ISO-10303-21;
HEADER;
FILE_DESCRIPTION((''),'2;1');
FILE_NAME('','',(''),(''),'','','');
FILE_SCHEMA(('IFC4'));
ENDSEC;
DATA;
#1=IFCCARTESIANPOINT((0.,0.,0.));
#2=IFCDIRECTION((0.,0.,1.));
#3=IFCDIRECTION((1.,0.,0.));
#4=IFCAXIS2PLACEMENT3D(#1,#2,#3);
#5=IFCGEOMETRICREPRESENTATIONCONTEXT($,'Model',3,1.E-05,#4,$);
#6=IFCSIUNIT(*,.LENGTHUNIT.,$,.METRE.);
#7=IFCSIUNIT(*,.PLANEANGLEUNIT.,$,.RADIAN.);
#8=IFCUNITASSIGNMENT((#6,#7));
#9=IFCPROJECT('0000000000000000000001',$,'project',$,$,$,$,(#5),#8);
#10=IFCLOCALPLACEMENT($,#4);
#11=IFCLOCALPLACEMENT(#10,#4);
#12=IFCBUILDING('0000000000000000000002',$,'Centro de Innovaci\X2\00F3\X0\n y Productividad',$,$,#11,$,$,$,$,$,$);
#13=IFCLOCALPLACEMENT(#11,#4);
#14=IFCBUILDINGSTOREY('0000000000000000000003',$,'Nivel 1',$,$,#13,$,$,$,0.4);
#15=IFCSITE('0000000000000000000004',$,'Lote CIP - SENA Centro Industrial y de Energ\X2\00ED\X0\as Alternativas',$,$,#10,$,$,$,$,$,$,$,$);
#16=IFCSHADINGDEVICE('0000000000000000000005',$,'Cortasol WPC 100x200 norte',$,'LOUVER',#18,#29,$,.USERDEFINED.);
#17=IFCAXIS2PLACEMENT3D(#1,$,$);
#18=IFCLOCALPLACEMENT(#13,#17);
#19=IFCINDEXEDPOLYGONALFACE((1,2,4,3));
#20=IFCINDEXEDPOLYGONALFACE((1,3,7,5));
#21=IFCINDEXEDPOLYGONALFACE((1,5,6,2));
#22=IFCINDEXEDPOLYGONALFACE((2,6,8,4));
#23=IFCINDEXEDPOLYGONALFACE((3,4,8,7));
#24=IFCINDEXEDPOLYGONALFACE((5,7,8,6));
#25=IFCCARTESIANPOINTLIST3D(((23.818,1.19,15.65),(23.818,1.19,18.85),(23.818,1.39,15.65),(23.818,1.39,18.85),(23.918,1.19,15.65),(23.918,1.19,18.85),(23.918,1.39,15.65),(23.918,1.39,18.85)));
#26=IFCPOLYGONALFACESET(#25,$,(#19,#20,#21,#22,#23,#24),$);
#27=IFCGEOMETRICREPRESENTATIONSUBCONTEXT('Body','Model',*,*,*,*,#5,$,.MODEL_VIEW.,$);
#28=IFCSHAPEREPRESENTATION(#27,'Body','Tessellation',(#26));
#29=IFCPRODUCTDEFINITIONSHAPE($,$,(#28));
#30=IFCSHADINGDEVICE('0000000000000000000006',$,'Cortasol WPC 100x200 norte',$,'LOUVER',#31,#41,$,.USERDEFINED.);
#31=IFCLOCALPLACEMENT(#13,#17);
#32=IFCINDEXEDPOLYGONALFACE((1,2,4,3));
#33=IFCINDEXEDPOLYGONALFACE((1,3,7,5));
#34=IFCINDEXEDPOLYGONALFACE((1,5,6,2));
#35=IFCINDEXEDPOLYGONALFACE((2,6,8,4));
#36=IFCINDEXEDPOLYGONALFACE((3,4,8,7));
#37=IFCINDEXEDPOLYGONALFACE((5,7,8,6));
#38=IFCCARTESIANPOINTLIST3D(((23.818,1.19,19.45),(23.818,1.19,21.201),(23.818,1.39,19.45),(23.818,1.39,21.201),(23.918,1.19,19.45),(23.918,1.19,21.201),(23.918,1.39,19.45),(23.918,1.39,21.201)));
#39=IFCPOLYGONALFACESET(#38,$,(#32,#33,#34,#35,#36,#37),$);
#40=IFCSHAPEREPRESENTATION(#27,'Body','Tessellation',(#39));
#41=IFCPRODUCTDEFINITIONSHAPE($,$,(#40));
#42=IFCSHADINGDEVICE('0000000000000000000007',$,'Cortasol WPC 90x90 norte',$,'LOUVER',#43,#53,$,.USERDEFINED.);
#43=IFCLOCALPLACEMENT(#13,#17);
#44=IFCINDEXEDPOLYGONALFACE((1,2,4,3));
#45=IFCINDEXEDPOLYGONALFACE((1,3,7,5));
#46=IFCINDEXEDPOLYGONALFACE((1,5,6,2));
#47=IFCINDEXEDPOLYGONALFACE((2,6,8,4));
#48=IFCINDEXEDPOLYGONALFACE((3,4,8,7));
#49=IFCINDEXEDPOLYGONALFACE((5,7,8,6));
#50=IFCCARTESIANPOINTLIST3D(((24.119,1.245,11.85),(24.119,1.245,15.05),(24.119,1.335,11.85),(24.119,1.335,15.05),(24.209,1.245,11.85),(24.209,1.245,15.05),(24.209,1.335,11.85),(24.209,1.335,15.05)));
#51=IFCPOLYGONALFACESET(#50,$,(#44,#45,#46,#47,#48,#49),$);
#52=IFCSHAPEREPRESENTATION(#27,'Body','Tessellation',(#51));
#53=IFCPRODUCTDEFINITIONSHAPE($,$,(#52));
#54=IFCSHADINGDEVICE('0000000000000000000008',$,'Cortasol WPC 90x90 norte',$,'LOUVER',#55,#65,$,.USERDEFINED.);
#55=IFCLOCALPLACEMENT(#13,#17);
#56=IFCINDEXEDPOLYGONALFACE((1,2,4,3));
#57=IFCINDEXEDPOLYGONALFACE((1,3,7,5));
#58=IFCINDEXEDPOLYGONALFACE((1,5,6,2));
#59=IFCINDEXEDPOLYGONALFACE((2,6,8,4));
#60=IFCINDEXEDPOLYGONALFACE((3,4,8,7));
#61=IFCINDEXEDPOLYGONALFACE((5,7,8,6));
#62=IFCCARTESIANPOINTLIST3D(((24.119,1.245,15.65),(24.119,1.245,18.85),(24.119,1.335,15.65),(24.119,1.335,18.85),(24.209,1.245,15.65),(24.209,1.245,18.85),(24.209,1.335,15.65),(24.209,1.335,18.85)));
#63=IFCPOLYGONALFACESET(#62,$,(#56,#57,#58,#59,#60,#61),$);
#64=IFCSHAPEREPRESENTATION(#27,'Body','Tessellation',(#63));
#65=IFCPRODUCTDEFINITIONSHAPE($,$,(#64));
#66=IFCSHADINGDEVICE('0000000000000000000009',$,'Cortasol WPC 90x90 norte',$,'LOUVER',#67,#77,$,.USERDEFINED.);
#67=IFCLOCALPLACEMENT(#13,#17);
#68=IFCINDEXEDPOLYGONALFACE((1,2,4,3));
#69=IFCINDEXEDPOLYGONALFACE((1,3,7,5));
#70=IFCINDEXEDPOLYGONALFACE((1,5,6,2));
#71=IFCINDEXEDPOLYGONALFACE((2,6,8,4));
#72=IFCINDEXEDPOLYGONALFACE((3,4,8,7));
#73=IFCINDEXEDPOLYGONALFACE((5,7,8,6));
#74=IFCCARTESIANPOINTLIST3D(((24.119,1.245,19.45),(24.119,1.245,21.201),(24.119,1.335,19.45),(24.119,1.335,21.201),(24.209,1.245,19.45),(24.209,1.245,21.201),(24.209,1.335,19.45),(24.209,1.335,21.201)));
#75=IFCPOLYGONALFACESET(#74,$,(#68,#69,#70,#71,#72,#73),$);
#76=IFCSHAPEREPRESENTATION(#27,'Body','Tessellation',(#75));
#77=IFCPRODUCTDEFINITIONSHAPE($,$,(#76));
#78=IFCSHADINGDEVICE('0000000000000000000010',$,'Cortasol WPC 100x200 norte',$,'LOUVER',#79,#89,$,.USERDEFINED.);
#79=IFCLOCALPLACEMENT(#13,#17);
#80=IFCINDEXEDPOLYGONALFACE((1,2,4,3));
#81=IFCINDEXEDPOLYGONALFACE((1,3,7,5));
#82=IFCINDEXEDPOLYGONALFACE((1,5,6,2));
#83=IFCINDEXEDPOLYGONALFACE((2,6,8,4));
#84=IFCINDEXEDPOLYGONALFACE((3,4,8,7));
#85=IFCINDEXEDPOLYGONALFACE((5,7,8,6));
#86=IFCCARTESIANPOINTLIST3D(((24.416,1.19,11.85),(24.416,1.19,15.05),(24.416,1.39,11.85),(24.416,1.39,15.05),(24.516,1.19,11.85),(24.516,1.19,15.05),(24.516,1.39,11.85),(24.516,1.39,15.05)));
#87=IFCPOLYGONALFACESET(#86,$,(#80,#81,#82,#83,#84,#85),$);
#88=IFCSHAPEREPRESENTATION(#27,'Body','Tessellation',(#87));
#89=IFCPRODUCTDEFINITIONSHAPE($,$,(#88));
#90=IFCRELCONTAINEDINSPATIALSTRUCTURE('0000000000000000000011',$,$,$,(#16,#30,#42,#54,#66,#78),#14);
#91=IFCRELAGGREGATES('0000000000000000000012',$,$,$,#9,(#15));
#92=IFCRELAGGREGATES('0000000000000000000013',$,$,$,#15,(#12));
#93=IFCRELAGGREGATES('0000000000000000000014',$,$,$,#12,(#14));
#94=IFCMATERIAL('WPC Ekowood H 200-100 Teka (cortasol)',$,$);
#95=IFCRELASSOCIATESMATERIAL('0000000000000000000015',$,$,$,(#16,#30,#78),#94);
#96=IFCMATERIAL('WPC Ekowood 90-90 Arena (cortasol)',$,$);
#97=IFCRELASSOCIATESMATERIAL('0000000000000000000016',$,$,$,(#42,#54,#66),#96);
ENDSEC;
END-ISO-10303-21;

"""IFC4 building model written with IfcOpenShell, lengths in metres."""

from ifc_helpers import new_model, si_unit, frame, origin_with_axes, place, context, subcontext, project, spatial, polyline, outline, extrude, material, element, save


model = new_model("IFC4")

# Units and contexts
model_context = context("Model", 3, precision=1e-05, world=origin_with_axes())
body_context = subcontext(model_context, "Body", "Model", "MODEL_VIEW")
ifc_project = project(units=[si_unit("LENGTHUNIT", "METRE"), si_unit("PLANEANGLEUNIT", "RADIAN")], contexts=[model_context])

# Site, building, storey
site_placement = place(None, origin_with_axes())
site = spatial("IfcSite", under=ifc_project, at=site_placement, Name="Lote CIP - SENA Centro Industrial y de Energías Alternativas")
building_placement = place(site_placement, origin_with_axes())
building = spatial("IfcBuilding", under=site, at=building_placement, Name="Centro de Innovación y Productividad")
storey_placement = place(building_placement, origin_with_axes())
storey = spatial("IfcBuildingStorey", under=building, at=storey_placement, Name="Nivel 1", Elevation=0.4)

# Shading devices
ifc_material_1 = material(Name="WPC Ekowood 90-90 Arena (cortasol)")
ifc_material_2 = material(Name="WPC Ekowood H 200-100 Teka (cortasol)")
shading_device_1_placement = place(storey_placement, origin_with_axes())
element("IfcShadingDevice", 1, at=shading_device_1_placement, inside=storey, material=ifc_material_2, Name="Cortasol WPC 100x200 norte", ObjectType="LOUVER", PredefinedType="USERDEFINED", context=body_context, shape_type="SweptSolid", body=[
    extrude(outline(polyline([(23.818, 1.19), (23.818, 1.39), (23.918, 1.39), (23.918, 1.19), (23.818, 1.19)])), frame((0.0, 0.0, 15.65)), (0.0, 0.0, 1.0), 3.2),
])
shading_device_2_placement = place(storey_placement, origin_with_axes())
element("IfcShadingDevice", 2, at=shading_device_2_placement, inside=storey, material=ifc_material_2, Name="Cortasol WPC 100x200 norte", ObjectType="LOUVER", PredefinedType="USERDEFINED", context=body_context, shape_type="SweptSolid", body=[
    extrude(outline(polyline([(23.818, 1.19), (23.818, 1.39), (23.918, 1.39), (23.918, 1.19), (23.818, 1.19)])), frame((0.0, 0.0, 19.45)), (0.0, 0.0, 1.0), 1.751),
])
shading_device_3_placement = place(storey_placement, origin_with_axes())
element("IfcShadingDevice", 3, at=shading_device_3_placement, inside=storey, material=ifc_material_1, Name="Cortasol WPC 90x90 norte", ObjectType="LOUVER", PredefinedType="USERDEFINED", context=body_context, shape_type="SweptSolid", body=[
    extrude(outline(polyline([(24.119, 1.245), (24.119, 1.335), (24.209, 1.335), (24.209, 1.245), (24.119, 1.245)])), frame((0.0, 0.0, 11.85)), (0.0, 0.0, 1.0), 3.2),
])
shading_device_4_placement = place(storey_placement, origin_with_axes())
element("IfcShadingDevice", 4, at=shading_device_4_placement, inside=storey, material=ifc_material_1, Name="Cortasol WPC 90x90 norte", ObjectType="LOUVER", PredefinedType="USERDEFINED", context=body_context, shape_type="SweptSolid", body=[
    extrude(outline(polyline([(24.119, 1.245), (24.119, 1.335), (24.209, 1.335), (24.209, 1.245), (24.119, 1.245)])), frame((0.0, 0.0, 15.65)), (0.0, 0.0, 1.0), 3.2),
])
shading_device_5_placement = place(storey_placement, origin_with_axes())
element("IfcShadingDevice", 5, at=shading_device_5_placement, inside=storey, material=ifc_material_1, Name="Cortasol WPC 90x90 norte", ObjectType="LOUVER", PredefinedType="USERDEFINED", context=body_context, shape_type="SweptSolid", body=[
    extrude(outline(polyline([(24.119, 1.245), (24.119, 1.335), (24.209, 1.335), (24.209, 1.245), (24.119, 1.245)])), frame((0.0, 0.0, 19.45)), (0.0, 0.0, 1.0), 1.751),
])
shading_device_6_placement = place(storey_placement, origin_with_axes())
element("IfcShadingDevice", 6, at=shading_device_6_placement, inside=storey, material=ifc_material_2, Name="Cortasol WPC 100x200 norte", ObjectType="LOUVER", PredefinedType="USERDEFINED", context=body_context, shape_type="SweptSolid", body=[
    extrude(outline(polyline([(24.416, 1.19), (24.416, 1.39), (24.516, 1.39), (24.516, 1.19), (24.416, 1.19)])), frame((0.0, 0.0, 11.85)), (0.0, 0.0, 1.0), 3.2),
])

save(model, "model.ifc")
